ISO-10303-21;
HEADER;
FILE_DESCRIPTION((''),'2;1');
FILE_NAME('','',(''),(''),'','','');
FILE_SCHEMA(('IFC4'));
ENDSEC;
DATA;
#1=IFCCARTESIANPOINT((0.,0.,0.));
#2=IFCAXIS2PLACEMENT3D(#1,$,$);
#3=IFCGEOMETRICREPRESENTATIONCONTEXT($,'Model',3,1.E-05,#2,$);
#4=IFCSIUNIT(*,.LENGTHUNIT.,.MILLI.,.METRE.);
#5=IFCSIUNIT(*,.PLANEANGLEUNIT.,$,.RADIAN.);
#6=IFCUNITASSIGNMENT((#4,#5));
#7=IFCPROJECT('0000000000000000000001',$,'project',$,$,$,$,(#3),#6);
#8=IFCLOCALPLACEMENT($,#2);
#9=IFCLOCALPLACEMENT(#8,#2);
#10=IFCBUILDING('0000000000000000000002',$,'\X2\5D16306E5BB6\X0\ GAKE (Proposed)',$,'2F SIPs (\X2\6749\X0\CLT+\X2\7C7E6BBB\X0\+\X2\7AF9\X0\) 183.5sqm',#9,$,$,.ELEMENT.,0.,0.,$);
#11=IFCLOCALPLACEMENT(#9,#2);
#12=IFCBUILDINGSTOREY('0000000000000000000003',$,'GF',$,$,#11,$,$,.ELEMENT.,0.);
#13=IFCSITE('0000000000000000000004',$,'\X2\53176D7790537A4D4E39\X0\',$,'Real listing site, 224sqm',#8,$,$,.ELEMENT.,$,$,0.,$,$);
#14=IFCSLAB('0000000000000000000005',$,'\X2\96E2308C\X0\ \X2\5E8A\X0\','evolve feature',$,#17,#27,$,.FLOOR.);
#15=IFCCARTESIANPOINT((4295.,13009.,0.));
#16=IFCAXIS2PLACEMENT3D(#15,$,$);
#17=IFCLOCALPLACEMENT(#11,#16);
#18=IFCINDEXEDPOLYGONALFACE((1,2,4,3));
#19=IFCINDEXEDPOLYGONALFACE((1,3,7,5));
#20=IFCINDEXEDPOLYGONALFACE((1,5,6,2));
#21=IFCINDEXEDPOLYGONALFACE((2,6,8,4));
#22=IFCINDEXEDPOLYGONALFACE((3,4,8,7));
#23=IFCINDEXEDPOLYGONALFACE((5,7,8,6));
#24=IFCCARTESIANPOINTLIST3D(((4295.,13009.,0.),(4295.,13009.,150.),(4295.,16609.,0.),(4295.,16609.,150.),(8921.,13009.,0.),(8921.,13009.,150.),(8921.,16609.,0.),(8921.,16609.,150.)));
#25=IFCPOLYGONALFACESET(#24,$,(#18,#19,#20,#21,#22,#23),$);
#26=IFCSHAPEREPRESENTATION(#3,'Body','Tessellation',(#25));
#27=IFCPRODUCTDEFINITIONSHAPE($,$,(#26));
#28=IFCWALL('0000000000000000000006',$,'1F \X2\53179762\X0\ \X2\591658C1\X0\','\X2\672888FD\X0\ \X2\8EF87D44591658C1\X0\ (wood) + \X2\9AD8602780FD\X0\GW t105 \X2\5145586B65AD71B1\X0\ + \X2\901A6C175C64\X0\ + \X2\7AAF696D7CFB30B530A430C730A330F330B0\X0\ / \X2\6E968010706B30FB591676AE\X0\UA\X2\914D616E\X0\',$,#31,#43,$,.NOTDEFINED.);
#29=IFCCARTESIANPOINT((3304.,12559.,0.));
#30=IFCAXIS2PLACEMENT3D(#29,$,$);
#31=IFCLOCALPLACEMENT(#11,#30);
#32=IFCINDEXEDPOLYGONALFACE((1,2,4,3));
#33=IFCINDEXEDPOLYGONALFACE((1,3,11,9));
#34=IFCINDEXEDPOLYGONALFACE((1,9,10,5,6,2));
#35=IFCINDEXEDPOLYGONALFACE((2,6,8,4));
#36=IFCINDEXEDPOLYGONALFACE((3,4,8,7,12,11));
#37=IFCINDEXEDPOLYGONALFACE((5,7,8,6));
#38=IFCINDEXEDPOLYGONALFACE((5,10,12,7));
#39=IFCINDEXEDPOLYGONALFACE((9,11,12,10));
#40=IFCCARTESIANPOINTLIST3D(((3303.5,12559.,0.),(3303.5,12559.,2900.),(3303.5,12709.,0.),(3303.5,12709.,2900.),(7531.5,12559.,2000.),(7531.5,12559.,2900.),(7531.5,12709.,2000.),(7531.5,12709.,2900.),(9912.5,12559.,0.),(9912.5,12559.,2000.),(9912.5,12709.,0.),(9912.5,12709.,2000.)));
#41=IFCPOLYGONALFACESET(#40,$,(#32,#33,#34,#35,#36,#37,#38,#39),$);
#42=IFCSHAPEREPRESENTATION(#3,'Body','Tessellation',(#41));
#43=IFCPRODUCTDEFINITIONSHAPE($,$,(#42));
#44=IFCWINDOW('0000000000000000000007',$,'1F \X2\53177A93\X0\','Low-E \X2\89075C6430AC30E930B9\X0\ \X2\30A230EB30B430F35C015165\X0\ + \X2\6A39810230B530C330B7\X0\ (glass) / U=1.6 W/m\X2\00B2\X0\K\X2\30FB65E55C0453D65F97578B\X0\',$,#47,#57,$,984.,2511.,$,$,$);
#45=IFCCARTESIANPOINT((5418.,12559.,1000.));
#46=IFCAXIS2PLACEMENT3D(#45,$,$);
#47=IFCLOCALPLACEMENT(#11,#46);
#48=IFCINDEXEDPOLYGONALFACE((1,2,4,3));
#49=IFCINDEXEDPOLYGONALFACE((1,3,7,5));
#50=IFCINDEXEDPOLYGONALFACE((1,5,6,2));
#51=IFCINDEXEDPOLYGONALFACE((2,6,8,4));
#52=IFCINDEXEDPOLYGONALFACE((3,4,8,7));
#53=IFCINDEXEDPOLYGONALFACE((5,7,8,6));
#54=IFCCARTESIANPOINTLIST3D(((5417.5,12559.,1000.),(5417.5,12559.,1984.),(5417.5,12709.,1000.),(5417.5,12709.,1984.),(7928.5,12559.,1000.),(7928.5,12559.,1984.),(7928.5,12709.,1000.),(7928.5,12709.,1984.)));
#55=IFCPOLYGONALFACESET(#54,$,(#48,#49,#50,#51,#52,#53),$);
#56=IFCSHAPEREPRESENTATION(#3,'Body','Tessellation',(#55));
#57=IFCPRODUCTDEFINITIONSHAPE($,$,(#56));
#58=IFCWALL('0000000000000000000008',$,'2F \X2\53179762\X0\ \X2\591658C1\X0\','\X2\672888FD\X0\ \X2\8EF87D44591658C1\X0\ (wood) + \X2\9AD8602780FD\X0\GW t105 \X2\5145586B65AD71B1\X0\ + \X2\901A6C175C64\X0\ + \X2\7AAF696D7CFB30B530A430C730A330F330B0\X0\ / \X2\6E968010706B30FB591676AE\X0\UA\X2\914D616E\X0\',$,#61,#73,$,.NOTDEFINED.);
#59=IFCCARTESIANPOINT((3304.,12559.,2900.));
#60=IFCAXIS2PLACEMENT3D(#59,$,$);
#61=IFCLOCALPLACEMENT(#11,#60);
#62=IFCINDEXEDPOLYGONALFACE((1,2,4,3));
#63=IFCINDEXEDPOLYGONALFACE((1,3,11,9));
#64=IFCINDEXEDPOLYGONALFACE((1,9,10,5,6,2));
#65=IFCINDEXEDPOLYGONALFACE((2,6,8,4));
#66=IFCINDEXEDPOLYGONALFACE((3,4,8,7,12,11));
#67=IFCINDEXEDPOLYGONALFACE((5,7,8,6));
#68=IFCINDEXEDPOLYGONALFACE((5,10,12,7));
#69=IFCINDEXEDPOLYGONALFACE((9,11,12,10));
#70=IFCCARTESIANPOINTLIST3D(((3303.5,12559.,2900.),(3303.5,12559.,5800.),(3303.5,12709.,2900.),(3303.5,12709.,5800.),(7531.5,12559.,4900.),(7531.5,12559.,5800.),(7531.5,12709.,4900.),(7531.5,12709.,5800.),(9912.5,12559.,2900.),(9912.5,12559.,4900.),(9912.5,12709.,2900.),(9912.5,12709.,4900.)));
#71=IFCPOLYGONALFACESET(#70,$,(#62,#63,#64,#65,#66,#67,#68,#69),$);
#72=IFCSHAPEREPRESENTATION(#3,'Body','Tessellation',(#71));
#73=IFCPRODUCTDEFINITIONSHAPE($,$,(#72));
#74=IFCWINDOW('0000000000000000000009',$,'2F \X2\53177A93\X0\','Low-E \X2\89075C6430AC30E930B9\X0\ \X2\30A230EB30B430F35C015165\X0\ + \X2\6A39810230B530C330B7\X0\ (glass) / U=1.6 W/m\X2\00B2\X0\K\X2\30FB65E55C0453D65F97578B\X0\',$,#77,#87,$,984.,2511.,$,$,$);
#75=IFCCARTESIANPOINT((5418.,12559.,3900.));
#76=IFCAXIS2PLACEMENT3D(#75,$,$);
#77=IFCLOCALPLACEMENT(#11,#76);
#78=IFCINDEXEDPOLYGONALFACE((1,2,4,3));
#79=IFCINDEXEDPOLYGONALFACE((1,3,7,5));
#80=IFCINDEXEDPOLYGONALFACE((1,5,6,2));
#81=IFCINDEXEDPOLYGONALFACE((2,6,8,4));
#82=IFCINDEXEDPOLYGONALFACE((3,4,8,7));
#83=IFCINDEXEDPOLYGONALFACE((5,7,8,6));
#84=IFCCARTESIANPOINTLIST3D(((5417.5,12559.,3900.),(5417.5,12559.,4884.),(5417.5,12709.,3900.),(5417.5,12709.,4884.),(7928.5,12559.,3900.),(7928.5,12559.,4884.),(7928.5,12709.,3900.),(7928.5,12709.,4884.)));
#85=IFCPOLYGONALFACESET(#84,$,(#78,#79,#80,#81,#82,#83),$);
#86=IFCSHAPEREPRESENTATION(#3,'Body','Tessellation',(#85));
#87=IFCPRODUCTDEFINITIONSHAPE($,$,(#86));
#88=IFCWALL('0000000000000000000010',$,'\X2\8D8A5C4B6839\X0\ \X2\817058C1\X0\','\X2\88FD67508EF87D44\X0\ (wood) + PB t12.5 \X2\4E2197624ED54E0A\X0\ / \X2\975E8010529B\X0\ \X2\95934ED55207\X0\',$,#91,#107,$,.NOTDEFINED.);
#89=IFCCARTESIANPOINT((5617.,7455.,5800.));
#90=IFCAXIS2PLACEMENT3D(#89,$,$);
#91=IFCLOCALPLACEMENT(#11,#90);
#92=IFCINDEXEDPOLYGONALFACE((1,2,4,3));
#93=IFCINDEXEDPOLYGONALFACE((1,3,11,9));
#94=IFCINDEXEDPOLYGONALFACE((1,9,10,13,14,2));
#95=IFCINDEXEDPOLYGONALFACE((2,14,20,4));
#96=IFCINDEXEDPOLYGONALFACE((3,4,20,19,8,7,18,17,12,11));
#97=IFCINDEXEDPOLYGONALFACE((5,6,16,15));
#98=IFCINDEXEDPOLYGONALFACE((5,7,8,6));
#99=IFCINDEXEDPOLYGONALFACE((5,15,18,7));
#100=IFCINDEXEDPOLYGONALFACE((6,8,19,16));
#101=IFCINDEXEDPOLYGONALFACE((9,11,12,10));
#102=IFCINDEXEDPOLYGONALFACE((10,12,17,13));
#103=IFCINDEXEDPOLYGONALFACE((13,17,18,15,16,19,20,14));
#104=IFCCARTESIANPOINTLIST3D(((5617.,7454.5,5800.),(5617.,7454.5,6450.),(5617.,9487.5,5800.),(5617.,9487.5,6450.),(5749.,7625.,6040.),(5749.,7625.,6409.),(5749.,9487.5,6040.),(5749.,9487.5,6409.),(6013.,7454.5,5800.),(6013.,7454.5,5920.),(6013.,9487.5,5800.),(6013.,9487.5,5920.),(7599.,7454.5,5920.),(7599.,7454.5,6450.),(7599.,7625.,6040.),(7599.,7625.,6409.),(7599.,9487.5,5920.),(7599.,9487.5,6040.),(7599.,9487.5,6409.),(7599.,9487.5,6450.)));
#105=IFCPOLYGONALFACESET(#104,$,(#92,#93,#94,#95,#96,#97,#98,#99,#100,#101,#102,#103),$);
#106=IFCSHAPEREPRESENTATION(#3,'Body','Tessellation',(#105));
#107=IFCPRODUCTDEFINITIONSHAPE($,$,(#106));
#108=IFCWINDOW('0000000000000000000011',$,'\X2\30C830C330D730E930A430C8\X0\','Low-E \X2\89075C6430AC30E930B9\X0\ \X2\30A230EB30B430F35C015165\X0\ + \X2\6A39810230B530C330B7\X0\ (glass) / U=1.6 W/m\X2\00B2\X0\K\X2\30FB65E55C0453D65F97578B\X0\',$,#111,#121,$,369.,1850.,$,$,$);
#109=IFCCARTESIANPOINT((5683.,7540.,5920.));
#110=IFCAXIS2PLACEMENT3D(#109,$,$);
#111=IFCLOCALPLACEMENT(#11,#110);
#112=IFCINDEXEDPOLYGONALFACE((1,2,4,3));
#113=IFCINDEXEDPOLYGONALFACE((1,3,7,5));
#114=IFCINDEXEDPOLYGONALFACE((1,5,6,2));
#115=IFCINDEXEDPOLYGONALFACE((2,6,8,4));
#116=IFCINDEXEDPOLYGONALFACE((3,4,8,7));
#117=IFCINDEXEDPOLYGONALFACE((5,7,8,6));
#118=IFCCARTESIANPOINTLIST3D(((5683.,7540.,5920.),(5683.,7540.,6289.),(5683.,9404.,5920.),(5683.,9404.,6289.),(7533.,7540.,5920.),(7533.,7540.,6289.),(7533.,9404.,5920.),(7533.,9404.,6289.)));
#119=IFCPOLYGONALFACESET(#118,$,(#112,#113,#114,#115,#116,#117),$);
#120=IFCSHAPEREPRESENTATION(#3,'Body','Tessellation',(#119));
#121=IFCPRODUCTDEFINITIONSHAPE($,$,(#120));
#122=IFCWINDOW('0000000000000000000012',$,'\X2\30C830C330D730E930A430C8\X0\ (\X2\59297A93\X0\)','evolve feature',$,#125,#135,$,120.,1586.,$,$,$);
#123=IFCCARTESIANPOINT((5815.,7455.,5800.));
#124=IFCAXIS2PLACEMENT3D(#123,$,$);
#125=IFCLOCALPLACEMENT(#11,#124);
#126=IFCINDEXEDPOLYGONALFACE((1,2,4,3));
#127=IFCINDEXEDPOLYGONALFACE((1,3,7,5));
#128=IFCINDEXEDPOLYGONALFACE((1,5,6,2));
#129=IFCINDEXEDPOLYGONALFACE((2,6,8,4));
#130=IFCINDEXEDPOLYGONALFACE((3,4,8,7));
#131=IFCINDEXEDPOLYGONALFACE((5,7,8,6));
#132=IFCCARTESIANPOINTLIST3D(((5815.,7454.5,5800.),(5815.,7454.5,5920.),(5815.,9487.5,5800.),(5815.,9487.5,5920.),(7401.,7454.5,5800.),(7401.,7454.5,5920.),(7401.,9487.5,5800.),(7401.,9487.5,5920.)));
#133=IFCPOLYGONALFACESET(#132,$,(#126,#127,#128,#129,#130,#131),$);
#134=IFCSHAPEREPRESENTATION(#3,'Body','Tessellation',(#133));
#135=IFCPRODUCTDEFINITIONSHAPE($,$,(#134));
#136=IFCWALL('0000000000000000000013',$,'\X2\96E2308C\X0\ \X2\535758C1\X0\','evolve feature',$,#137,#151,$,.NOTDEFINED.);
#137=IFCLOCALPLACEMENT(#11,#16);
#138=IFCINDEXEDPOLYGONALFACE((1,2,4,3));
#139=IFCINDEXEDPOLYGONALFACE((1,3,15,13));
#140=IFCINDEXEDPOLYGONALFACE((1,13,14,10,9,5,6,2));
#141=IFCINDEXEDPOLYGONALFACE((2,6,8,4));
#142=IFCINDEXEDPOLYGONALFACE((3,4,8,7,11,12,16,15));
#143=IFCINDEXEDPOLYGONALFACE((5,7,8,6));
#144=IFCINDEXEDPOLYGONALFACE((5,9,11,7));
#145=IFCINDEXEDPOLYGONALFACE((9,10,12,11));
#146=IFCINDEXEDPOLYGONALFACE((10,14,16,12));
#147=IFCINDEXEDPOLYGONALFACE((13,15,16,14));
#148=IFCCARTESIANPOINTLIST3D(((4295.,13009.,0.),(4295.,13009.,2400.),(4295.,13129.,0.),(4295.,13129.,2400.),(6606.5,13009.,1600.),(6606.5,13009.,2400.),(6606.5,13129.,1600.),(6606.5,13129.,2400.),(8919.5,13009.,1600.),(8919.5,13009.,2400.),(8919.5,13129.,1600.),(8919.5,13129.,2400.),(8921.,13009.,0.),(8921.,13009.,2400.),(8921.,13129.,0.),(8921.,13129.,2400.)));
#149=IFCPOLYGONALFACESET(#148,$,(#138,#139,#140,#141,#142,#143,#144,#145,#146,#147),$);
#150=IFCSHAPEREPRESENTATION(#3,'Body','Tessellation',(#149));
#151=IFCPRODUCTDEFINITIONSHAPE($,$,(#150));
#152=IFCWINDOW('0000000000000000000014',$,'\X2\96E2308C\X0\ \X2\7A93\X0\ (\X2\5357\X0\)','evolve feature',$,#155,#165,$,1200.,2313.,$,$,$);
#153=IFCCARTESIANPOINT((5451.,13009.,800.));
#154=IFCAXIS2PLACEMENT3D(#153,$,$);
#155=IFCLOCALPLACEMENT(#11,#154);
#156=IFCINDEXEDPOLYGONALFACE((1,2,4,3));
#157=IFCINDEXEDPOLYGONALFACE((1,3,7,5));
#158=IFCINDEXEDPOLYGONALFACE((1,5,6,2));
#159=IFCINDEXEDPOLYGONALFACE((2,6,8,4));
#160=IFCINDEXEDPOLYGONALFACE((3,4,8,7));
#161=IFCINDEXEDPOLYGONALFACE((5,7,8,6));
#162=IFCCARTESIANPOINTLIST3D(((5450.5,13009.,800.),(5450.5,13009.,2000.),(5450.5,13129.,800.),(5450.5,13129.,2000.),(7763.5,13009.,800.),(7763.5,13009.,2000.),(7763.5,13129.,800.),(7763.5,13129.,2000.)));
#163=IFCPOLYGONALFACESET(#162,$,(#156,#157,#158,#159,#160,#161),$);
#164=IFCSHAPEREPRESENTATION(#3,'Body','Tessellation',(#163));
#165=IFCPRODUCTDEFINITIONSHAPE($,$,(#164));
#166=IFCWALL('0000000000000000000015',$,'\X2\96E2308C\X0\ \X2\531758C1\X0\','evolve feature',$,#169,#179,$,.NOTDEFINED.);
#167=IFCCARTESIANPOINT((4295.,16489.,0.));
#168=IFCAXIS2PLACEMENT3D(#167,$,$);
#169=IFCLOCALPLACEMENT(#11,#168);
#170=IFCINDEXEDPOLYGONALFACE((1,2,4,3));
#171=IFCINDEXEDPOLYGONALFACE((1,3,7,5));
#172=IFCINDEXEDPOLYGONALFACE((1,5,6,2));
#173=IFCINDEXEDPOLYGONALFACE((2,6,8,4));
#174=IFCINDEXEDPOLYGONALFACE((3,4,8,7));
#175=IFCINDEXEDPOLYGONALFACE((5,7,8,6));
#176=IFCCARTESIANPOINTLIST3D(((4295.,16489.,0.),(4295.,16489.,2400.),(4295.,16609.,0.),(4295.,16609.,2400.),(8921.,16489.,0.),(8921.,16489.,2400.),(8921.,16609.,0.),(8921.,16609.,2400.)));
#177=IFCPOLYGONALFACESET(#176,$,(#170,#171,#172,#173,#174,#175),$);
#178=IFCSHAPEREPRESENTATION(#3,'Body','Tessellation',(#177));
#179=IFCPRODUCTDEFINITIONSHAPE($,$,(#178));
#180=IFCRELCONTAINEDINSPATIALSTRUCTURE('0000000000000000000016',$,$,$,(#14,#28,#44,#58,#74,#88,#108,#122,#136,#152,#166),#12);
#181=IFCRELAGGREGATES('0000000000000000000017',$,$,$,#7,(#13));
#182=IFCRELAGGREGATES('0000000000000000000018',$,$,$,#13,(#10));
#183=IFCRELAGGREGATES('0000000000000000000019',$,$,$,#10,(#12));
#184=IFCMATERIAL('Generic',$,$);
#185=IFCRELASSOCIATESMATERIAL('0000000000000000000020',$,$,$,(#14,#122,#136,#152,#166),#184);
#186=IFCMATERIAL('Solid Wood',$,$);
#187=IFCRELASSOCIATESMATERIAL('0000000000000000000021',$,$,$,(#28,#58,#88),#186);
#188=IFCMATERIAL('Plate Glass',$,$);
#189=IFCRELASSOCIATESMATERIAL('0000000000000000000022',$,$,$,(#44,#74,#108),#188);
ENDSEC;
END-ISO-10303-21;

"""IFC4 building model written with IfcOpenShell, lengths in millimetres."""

from ifc_helpers import new_model, si_unit, frame, frame_2d, origin, place, context, project, spatial, rectangle, extrude, material, element, fill, save


model = new_model("IFC4")

# Units and contexts
model_context = context("Model", 3, precision=1e-05, world=origin())
ifc_project = project(units=[si_unit("LENGTHUNIT", "METRE", prefix="MILLI"), si_unit("PLANEANGLEUNIT", "RADIAN")], contexts=[model_context])

# Site, building, storey
site_placement = place(None, origin())
site = spatial("IfcSite", under=ifc_project, at=site_placement, Name="北海道積丹", ObjectType="Real listing site, 224sqm", CompositionType="ELEMENT", RefElevation=0.0)
building_placement = place(site_placement, origin())
building = spatial("IfcBuilding", under=site, at=building_placement, Name="崖の家 GAKE (Proposed)", ObjectType="2F SIPs (杉CLT+籾殻+竹) 183.5sqm", CompositionType="ELEMENT", ElevationOfRefHeight=0.0, ElevationOfTerrain=0.0)
storey_placement = place(building_placement, origin())
storey = spatial("IfcBuildingStorey", under=building, at=storey_placement, Name="GF", CompositionType="ELEMENT", Elevation=0.0)

# Slab
ifc_material_1 = material(Name="Generic")
slab_placement = place(storey_placement, frame((4295.0, 13009.0, 0.0)))
element("IfcSlab", 1, at=slab_placement, inside=storey, material=ifc_material_1, Name="離れ 床", Description="evolve feature", PredefinedType="FLOOR", context=model_context, shape_type="SweptSolid", body=[
    extrude(rectangle(XDim=4626.0, YDim=3600.0, at=frame_2d((2313.0, 1800.0))), frame((4295.0, 13009.0, 0.0)), (0.0, 0.0, 1.0), 150.0),
])

# Wall, opening, window
ifc_material_2 = material(Name="Solid Wood")
wall_1_placement = place(storey_placement, frame((3304.0, 12559.0, 0.0)))
wall_1 = element("IfcWall", 2, at=wall_1_placement, inside=storey, material=ifc_material_2, Name="1F 北面 外壁", Description="木製 軸組外壁 (wood) + 高性能GW t105 充填断熱 + 通気層 + 窯業系サイディング / 準耐火・外皮UA配慮", PredefinedType="NOTDEFINED", context=model_context, shape_type="SweptSolid", body=[
    extrude(rectangle(XDim=6609.0, YDim=150.0, at=frame_2d((3304.0, 75.0))), frame((3304.0, 12559.0, 0.0)), (0.0, 0.0, 1.0), 2900.0),
])
opening_1_placement = place(storey_placement, frame((5418.0, 12559.0, 1000.0)))
opening_1 = element("IfcOpeningElement", 3, at=opening_1_placement, cuts=wall_1, PredefinedType="NOTDEFINED", context=model_context, shape_type="SweptSolid", body=[
    extrude(rectangle(XDim=2511.0, YDim=150.0, at=frame_2d((1255.0, 75.0))), frame((5418.0, 12559.0, 1000.0)), (0.0, 0.0, 1.0), 984.0),
])
ifc_material_3 = material(Name="Plate Glass")
window_1_placement = place(storey_placement, frame((5418.0, 12559.0, 1000.0)))
window_1 = element("IfcWindow", 4, at=window_1_placement, inside=storey, material=ifc_material_3, Name="1F 北窓", Description="Low-E 複層ガラス アルゴン封入 + 樹脂サッシ (glass) / U=1.6 W/m²K・日射取得型", OverallHeight=984.0, OverallWidth=2511.0, context=model_context, shape_type="SweptSolid", body=[
    extrude(rectangle(XDim=2511.0, YDim=150.0, at=frame_2d((1255.0, 75.0))), frame((5418.0, 12559.0, 1000.0)), (0.0, 0.0, 1.0), 984.0),
])
fill(opening_1, window_1)

# Wall, opening, window
wall_2_placement = place(storey_placement, frame((3304.0, 12559.0, 2900.0)))
wall_2 = element("IfcWall", 5, at=wall_2_placement, inside=storey, material=ifc_material_2, Name="2F 北面 外壁", Description="木製 軸組外壁 (wood) + 高性能GW t105 充填断熱 + 通気層 + 窯業系サイディング / 準耐火・外皮UA配慮", PredefinedType="NOTDEFINED", context=model_context, shape_type="SweptSolid", body=[
    extrude(rectangle(XDim=6609.0, YDim=150.0, at=frame_2d((3304.0, 75.0))), frame((3304.0, 12559.0, 2900.0)), (0.0, 0.0, 1.0), 2900.0),
])
opening_2_placement = place(storey_placement, frame((5418.0, 12559.0, 3900.0)))
opening_2 = element("IfcOpeningElement", 6, at=opening_2_placement, cuts=wall_2, PredefinedType="NOTDEFINED", context=model_context, shape_type="SweptSolid", body=[
    extrude(rectangle(XDim=2511.0, YDim=150.0, at=frame_2d((1255.0, 75.0))), frame((5418.0, 12559.0, 3900.0)), (0.0, 0.0, 1.0), 984.0),
])
window_2_placement = place(storey_placement, frame((5418.0, 12559.0, 3900.0)))
window_2 = element("IfcWindow", 7, at=window_2_placement, inside=storey, material=ifc_material_3, Name="2F 北窓", Description="Low-E 複層ガラス アルゴン封入 + 樹脂サッシ (glass) / U=1.6 W/m²K・日射取得型", OverallHeight=984.0, OverallWidth=2511.0, context=model_context, shape_type="SweptSolid", body=[
    extrude(rectangle(XDim=2511.0, YDim=150.0, at=frame_2d((1255.0, 75.0))), frame((5418.0, 12559.0, 3900.0)), (0.0, 0.0, 1.0), 984.0),
])
fill(opening_2, window_2)

# Wall, openings, windows
wall_3_placement = place(storey_placement, frame((5617.0, 7455.0, 5800.0)))
wall_3 = element("IfcWall", 8, at=wall_3_placement, inside=storey, material=ifc_material_2, Name="越屋根 腰壁", Description="製材軸組 (wood) + PB t12.5 両面仕上 / 非耐力 間仕切", PredefinedType="NOTDEFINED", context=model_context, shape_type="SweptSolid", body=[
    extrude(rectangle(XDim=1982.0, YDim=2033.0, at=frame_2d((991.0, 1016.0))), frame((5617.0, 7455.0, 5800.0)), (0.0, 0.0, 1.0), 650.0),
])
opening_3_placement = place(storey_placement, frame((5683.0, 7540.0, 5920.0)))
opening_3 = element("IfcOpeningElement", 9, at=opening_3_placement, cuts=wall_3, PredefinedType="NOTDEFINED", context=model_context, shape_type="SweptSolid", body=[
    extrude(rectangle(XDim=1850.0, YDim=1864.0, at=frame_2d((925.0, 932.0))), frame((5683.0, 7540.0, 5920.0)), (0.0, 0.0, 1.0), 369.0),
])
opening_4_placement = place(storey_placement, frame((5815.0, 7455.0, 5800.0)))
opening_4 = element("IfcOpeningElement", 10, at=opening_4_placement, cuts=wall_3, PredefinedType="NOTDEFINED", context=model_context, shape_type="SweptSolid", body=[
    extrude(rectangle(XDim=1586.0, YDim=2033.0, at=frame_2d((793.0, 1016.0))), frame((5815.0, 7455.0, 5800.0)), (0.0, 0.0, 1.0), 120.0),
])
window_3_placement = place(storey_placement, frame((5683.0, 7540.0, 5920.0)))
window_3 = element("IfcWindow", 11, at=window_3_placement, inside=storey, material=ifc_material_3, Name="トップライト", Description="Low-E 複層ガラス アルゴン封入 + 樹脂サッシ (glass) / U=1.6 W/m²K・日射取得型", OverallHeight=369.0, OverallWidth=1850.0, context=model_context, shape_type="SweptSolid", body=[
    extrude(rectangle(XDim=1850.0, YDim=1864.0, at=frame_2d((925.0, 932.0))), frame((5683.0, 7540.0, 5920.0)), (0.0, 0.0, 1.0), 369.0),
])
fill(opening_3, window_3)
window_4_placement = place(storey_placement, frame((5815.0, 7455.0, 5800.0)))
window_4 = element("IfcWindow", 12, at=window_4_placement, inside=storey, material=ifc_material_1, Name="トップライト (天窓)", Description="evolve feature", OverallHeight=120.0, OverallWidth=1586.0, context=model_context, shape_type="SweptSolid", body=[
    extrude(rectangle(XDim=1586.0, YDim=2033.0, at=frame_2d((793.0, 1016.0))), frame((5815.0, 7455.0, 5800.0)), (0.0, 0.0, 1.0), 120.0),
])
fill(opening_4, window_4)

# Wall, opening, window
wall_4_placement = place(storey_placement, frame((4295.0, 13009.0, 0.0)))
wall_4 = element("IfcWall", 13, at=wall_4_placement, inside=storey, material=ifc_material_1, Name="離れ 南壁", Description="evolve feature", PredefinedType="NOTDEFINED", context=model_context, shape_type="SweptSolid", body=[
    extrude(rectangle(XDim=4626.0, YDim=120.0, at=frame_2d((2313.0, 60.0))), frame((4295.0, 13009.0, 0.0)), (0.0, 0.0, 1.0), 2400.0),
])
opening_5_placement = place(storey_placement, frame((5451.0, 13009.0, 800.0)))
opening_5 = element("IfcOpeningElement", 14, at=opening_5_placement, cuts=wall_4, PredefinedType="NOTDEFINED", context=model_context, shape_type="SweptSolid", body=[
    extrude(rectangle(XDim=2313.0, YDim=120.0, at=frame_2d((1156.0, 60.0))), frame((5451.0, 13009.0, 800.0)), (0.0, 0.0, 1.0), 1200.0),
])
window_5_placement = place(storey_placement, frame((5451.0, 13009.0, 800.0)))
window_5 = element("IfcWindow", 15, at=window_5_placement, inside=storey, material=ifc_material_1, Name="離れ 窓 (南)", Description="evolve feature", OverallHeight=1200.0, OverallWidth=2313.0, context=model_context, shape_type="SweptSolid", body=[
    extrude(rectangle(XDim=2313.0, YDim=120.0, at=frame_2d((1156.0, 60.0))), frame((5451.0, 13009.0, 800.0)), (0.0, 0.0, 1.0), 1200.0),
])
fill(opening_5, window_5)

# Wall
wall_5_placement = place(storey_placement, frame((4295.0, 16489.0, 0.0)))
element("IfcWall", 16, at=wall_5_placement, inside=storey, material=ifc_material_1, Name="離れ 北壁", Description="evolve feature", PredefinedType="NOTDEFINED", context=model_context, shape_type="SweptSolid", body=[
    extrude(rectangle(XDim=4626.0, YDim=120.0, at=frame_2d((2313.0, 60.0))), frame((4295.0, 16489.0, 0.0)), (0.0, 0.0, 1.0), 2400.0),
])

save(model, "model.ifc")
